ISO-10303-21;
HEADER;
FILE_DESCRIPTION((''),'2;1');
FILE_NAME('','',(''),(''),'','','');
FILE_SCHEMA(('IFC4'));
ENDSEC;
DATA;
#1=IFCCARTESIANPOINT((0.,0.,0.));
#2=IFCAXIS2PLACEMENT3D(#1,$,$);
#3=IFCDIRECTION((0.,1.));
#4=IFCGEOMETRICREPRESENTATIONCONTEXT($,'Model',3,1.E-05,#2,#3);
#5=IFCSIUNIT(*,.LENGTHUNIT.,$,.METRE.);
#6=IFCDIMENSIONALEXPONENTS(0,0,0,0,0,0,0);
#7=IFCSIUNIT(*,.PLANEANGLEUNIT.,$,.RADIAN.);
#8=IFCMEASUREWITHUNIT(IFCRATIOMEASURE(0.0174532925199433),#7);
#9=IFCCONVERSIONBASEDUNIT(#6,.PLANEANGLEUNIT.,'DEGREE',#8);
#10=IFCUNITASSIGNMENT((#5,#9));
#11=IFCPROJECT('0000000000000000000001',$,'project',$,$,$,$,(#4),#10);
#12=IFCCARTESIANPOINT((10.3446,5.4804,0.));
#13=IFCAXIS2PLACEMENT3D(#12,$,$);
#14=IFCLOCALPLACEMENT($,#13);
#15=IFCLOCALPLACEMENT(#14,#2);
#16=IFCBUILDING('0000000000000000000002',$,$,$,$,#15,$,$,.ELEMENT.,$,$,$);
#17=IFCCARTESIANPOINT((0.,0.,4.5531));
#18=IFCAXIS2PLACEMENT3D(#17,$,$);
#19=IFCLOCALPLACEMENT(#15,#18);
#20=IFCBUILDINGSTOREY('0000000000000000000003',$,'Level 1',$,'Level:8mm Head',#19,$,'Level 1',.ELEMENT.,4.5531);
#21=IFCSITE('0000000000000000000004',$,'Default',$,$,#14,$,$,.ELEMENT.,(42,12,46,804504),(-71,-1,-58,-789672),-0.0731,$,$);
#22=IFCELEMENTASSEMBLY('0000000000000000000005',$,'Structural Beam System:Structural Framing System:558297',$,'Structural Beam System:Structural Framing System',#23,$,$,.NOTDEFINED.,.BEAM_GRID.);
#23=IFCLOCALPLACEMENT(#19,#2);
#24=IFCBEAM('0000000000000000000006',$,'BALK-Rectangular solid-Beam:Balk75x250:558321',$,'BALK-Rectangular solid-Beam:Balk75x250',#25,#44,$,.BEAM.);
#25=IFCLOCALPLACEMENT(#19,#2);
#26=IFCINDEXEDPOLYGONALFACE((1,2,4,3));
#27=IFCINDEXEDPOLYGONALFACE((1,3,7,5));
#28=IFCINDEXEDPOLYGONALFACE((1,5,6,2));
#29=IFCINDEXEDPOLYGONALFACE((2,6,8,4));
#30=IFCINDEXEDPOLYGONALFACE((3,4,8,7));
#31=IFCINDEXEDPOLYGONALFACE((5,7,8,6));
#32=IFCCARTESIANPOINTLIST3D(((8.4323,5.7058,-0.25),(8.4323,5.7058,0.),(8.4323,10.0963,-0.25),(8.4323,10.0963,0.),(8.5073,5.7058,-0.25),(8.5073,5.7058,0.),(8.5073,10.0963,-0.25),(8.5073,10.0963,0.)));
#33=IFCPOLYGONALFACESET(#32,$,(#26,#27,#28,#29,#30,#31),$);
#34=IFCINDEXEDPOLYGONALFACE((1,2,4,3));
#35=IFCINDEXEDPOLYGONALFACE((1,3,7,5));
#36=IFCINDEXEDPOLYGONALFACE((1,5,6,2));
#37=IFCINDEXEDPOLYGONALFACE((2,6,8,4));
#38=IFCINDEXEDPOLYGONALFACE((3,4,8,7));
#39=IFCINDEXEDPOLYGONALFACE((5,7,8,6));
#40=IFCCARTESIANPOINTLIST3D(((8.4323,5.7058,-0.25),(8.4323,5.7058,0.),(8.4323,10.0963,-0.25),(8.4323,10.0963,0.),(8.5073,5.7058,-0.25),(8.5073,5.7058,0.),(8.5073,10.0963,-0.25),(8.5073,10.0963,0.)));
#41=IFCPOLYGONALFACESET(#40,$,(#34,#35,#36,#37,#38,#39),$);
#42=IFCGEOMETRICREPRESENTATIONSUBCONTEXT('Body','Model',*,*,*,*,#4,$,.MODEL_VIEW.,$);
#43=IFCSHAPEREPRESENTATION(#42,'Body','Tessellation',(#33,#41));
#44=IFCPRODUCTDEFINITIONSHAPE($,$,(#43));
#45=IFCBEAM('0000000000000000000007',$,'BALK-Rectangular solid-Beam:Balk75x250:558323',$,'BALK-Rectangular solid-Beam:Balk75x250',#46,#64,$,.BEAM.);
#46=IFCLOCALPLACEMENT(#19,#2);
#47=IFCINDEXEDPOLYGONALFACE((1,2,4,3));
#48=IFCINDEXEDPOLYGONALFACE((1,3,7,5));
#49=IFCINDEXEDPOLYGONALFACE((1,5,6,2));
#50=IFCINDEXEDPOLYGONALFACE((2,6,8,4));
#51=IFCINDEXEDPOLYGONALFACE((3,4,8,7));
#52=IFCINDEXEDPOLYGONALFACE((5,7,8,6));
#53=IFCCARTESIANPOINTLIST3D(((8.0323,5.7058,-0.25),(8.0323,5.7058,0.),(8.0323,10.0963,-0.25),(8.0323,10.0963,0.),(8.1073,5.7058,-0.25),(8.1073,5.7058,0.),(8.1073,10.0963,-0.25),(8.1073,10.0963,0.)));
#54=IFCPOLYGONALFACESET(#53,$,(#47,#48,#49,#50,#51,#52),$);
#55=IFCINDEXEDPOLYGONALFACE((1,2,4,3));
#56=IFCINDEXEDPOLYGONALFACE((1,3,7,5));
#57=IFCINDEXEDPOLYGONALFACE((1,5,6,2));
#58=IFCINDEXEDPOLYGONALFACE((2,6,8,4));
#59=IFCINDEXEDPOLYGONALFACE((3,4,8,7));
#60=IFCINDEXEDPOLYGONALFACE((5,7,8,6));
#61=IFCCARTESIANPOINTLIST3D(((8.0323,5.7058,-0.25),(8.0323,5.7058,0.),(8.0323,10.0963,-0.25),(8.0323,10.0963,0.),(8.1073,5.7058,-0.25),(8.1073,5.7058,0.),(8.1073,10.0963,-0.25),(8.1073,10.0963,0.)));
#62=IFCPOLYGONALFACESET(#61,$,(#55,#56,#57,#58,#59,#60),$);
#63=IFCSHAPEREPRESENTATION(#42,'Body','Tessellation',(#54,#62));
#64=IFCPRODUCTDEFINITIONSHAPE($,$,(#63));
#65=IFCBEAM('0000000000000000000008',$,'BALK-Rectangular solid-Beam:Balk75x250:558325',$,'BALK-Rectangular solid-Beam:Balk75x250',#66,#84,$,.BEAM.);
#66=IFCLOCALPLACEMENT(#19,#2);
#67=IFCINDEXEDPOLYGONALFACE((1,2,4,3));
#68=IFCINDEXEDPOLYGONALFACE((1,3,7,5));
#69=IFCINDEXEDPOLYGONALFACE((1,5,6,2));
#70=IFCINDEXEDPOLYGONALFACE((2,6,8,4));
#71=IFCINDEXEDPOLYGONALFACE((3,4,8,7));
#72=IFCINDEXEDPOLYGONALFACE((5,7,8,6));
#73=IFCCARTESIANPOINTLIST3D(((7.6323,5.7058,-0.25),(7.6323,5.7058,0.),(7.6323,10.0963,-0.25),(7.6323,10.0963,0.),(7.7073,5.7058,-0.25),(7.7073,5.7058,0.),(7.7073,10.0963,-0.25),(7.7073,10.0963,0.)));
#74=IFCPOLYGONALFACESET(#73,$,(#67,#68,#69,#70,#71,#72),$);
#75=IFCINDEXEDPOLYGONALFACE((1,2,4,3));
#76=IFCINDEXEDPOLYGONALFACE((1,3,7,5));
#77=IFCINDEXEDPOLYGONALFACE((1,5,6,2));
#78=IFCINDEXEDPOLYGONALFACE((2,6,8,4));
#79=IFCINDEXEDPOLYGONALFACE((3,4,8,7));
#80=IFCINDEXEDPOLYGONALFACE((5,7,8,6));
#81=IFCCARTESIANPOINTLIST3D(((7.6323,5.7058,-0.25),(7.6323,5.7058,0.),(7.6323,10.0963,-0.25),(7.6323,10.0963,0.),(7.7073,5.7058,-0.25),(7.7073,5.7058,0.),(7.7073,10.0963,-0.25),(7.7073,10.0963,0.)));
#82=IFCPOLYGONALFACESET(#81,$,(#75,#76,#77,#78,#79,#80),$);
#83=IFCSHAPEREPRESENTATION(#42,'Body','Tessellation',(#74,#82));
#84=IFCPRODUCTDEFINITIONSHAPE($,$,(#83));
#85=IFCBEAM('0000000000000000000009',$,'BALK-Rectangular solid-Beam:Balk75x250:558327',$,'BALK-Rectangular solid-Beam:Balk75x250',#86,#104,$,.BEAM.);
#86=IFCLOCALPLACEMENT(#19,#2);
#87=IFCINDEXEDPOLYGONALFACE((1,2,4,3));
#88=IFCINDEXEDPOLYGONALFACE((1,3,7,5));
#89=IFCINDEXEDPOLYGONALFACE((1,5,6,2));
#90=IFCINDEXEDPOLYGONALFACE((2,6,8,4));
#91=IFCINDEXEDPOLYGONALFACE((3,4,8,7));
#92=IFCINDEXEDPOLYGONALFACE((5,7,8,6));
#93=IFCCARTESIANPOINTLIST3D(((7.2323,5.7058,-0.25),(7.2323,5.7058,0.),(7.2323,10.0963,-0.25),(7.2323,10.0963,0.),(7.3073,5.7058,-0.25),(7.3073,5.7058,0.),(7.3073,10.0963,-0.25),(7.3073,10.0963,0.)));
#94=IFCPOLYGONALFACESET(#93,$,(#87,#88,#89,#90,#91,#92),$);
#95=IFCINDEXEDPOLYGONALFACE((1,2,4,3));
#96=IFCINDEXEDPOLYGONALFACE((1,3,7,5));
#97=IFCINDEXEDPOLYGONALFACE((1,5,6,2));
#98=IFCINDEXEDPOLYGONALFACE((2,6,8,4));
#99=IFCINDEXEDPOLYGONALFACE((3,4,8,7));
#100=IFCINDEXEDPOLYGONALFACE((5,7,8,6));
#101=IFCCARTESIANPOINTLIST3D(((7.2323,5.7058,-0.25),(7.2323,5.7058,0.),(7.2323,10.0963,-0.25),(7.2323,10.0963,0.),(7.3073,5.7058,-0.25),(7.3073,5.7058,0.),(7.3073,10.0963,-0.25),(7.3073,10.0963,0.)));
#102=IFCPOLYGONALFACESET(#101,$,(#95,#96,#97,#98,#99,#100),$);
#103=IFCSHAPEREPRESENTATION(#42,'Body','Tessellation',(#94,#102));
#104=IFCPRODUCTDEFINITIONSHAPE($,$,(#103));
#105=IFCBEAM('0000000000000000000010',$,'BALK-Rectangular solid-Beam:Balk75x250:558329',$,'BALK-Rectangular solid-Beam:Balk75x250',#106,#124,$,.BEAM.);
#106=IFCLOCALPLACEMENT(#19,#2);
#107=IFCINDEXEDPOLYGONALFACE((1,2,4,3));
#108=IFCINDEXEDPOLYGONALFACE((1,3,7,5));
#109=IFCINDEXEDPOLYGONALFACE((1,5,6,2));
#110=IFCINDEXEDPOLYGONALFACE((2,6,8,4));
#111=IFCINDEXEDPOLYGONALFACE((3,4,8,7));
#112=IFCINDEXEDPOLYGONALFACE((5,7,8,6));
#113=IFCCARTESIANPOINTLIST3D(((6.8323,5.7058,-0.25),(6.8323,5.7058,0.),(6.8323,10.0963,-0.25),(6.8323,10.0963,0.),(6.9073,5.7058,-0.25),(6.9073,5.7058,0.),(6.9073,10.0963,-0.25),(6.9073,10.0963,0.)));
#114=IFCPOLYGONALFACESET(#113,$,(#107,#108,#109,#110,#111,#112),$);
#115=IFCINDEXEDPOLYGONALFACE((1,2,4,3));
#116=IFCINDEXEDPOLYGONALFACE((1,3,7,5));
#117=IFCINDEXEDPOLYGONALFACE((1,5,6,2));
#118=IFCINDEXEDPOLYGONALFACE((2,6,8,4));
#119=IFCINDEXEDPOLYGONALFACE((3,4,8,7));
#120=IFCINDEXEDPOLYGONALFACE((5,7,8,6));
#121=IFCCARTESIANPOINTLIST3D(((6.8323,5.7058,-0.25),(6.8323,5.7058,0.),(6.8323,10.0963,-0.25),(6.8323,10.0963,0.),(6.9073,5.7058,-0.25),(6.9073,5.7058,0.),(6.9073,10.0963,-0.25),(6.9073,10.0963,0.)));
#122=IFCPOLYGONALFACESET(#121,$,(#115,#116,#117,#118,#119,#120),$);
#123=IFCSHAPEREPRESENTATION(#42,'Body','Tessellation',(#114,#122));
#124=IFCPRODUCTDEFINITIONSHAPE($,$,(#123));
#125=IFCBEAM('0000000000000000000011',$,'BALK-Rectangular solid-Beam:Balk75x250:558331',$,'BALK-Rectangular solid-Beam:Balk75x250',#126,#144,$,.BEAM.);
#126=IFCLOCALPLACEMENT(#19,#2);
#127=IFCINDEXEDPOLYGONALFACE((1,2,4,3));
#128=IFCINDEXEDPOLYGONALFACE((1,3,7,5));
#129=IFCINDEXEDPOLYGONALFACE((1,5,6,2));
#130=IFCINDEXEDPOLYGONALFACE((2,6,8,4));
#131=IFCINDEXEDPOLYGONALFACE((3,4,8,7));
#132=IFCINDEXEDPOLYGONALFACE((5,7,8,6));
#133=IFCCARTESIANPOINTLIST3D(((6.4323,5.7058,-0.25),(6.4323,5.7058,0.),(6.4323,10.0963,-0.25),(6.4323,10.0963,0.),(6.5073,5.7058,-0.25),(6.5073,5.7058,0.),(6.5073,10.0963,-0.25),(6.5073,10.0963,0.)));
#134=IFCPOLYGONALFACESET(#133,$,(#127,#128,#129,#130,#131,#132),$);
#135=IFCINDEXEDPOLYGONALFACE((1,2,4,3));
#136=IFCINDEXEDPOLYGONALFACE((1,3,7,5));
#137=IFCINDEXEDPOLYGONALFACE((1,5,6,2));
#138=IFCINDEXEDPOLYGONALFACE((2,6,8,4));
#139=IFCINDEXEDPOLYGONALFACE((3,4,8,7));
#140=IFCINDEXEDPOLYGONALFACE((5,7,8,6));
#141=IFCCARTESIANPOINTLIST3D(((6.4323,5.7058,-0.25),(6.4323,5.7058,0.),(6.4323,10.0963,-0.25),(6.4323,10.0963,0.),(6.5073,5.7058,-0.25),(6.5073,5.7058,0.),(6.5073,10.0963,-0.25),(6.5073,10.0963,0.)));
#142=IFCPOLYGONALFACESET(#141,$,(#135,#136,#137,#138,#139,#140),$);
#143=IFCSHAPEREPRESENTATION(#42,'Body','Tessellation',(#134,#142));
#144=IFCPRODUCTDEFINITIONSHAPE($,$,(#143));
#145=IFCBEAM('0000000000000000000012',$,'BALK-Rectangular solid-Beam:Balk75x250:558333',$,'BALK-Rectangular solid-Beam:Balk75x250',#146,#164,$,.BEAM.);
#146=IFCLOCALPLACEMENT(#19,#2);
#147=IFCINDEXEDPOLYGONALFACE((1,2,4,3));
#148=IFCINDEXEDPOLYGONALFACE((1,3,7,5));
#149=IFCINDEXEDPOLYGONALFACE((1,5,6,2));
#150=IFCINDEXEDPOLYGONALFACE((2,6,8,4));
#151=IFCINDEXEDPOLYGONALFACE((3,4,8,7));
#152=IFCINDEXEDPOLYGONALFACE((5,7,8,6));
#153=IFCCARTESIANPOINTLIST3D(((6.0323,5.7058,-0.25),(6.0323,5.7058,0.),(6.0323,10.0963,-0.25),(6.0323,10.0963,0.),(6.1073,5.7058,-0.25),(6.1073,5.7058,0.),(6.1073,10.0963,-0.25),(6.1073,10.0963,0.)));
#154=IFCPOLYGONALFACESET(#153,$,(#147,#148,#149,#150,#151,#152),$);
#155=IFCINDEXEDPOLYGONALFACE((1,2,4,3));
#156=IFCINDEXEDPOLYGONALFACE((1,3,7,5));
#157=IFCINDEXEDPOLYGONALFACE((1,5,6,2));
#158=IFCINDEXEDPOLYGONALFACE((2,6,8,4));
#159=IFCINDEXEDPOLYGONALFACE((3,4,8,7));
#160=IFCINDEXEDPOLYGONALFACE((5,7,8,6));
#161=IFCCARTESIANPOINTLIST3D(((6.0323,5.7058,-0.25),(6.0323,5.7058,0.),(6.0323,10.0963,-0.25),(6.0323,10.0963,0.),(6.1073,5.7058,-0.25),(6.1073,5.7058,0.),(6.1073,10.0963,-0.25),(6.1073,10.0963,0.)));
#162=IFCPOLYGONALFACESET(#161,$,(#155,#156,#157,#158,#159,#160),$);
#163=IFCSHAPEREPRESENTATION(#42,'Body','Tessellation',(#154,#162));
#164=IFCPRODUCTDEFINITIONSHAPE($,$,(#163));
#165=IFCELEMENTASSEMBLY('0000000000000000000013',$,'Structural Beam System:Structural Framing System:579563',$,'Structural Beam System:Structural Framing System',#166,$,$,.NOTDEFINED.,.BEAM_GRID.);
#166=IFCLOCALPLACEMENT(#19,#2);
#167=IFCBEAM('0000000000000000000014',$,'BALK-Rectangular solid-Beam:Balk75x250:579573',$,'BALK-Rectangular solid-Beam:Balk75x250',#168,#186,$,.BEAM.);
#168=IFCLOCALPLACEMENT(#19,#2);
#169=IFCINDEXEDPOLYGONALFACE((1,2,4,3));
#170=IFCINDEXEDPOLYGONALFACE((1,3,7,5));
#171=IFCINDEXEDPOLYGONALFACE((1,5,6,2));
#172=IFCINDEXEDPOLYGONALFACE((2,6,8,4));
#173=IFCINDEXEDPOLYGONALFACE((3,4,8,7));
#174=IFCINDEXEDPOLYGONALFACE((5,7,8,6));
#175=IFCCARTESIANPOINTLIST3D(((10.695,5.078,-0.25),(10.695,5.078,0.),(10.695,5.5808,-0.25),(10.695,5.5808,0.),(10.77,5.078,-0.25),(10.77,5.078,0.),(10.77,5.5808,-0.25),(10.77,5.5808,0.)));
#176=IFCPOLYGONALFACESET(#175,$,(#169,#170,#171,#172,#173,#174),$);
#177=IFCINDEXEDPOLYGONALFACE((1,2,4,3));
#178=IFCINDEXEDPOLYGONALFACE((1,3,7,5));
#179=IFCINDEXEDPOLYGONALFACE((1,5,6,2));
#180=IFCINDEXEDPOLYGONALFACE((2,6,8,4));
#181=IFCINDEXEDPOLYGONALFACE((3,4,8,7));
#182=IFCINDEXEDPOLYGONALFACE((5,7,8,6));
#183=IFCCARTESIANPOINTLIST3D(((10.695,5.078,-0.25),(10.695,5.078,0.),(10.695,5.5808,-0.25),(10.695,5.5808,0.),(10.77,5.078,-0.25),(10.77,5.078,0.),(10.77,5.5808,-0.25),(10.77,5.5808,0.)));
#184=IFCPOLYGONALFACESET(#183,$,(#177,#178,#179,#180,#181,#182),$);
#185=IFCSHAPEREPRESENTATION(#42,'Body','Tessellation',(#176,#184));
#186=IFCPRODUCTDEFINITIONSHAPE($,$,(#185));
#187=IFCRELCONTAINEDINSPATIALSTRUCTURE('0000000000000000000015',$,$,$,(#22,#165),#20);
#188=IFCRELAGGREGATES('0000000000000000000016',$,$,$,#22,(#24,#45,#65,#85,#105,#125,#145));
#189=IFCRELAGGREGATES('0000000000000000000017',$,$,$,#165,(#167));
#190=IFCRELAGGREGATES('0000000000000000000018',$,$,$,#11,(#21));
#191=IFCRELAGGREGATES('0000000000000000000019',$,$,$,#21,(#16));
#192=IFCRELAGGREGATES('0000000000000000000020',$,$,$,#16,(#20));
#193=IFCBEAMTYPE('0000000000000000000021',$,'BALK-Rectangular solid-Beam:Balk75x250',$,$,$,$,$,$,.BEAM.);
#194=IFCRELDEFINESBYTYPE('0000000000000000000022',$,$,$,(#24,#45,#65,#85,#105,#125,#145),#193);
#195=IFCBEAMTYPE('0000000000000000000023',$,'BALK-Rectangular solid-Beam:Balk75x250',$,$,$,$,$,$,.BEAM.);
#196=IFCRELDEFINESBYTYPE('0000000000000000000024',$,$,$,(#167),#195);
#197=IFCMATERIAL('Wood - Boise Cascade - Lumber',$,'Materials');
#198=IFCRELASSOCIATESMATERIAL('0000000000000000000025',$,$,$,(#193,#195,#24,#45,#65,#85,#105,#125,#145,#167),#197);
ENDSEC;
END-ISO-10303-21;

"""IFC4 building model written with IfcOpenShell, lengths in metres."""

from ifc_helpers import new_model, entity, si_unit, converted_unit, direction, frame, frame_2d, origin, origin_2d_with_axis, place, context, subcontext, project, spatial, rectangle, extrude, source, transform, mapped, material, material_profile, profile_set, profile_usage, type_object, type_shapes, element, aggregate, save


model = new_model("IFC4")

# Units and contexts
model_context = context("Model", 3, precision=1e-05, world=origin(), true_north=direction((0.0, 1.0)))
body_context = subcontext(model_context, "Body", "Model", "MODEL_VIEW")
ifc_project = project(units=[si_unit("LENGTHUNIT", "METRE"), converted_unit("PLANEANGLEUNIT", "DEGREE", entity("IfcRatioMeasure", 0.0174532925199433), si_unit("PLANEANGLEUNIT", "RADIAN"), dimensions=[0, 0, 0, 0, 0, 0, 0])], contexts=[model_context])

# Site, building, storey
site_placement = place(None, frame((10.3446, 5.4804, 0.0)))
site = spatial("IfcSite", under=ifc_project, at=site_placement, Name="Default", CompositionType="ELEMENT", RefLatitude=(42, 12, 46, 804504), RefLongitude=(-71, -1, -58, -789672), RefElevation=-0.0731)
building_placement = place(site_placement, origin())
building = spatial("IfcBuilding", under=site, at=building_placement, CompositionType="ELEMENT")
storey_placement = place(building_placement, frame((0.0, 0.0, 4.5531)))
storey = spatial("IfcBuildingStorey", under=building, at=storey_placement, Name="Level 1", ObjectType="Level:8mm Head", LongName="Level 1", CompositionType="ELEMENT", Elevation=4.5531)

# Element assemblies, beams
assembly_1_placement = place(storey_placement, origin())
assembly_1 = element("IfcElementAssembly", 1, at=assembly_1_placement, inside=storey, Name="Structural Beam System:Structural Framing System:558297", ObjectType="Structural Beam System:Structural Framing System", AssemblyPlace="NOTDEFINED", PredefinedType="BEAM_GRID")
ifc_material_1 = material(Name="Wood - Boise Cascade - Lumber", Category="Materials")
ifc_material_profile = material_profile(ifc_material_1, rectangle(XDim=0.25, YDim=0.075, at=frame_2d((0.0, 0.0), x_axis=(1.0, 0.0))), Name="Balk75x250")
ifc_profile_set = profile_set([ifc_material_profile], Name="Balk75x250")
beam_type_1 = type_object("IfcBeamType", Name="BALK-Rectangular solid-Beam:Balk75x250", PredefinedType="BEAM", material=ifc_profile_set)
shared_shape_1 = source(origin(), body_context, "Body", "SweptSolid", [
    extrude(rectangle(XDim=0.25, YDim=0.075, at=origin_2d_with_axis()), frame((-2.089, 0.0, 0.0), z_axis=(1.0, 0.0, 0.0), x_axis=(0.0, 0.0, -1.0)), (0.0, 0.0, 1.0), 4.3905),
    extrude(rectangle(XDim=0.25, YDim=0.075, at=origin_2d_with_axis()), frame((-2.089, 0.0, 0.0), z_axis=(1.0, 0.0, 0.0), x_axis=(0.0, 0.0, -1.0)), (0.0, 0.0, 1.0), 4.3905),
])
type_shapes(beam_type_1, [shared_shape_1])
ifc_profile_usage_1 = profile_usage(ifc_profile_set, cardinal=8)
beam_1_placement = place(assembly_1_placement, frame((8.4698, 8.0073, -0.125), z_axis=(0.0, 0.0, 1.0), x_axis=(0.0, -1.0, 0.0)))
beam_1 = element("IfcBeam", 2, at=beam_1_placement, type_object=beam_type_1, material=ifc_profile_usage_1, Name="BALK-Rectangular solid-Beam:Balk75x250:558321", ObjectType="BALK-Rectangular solid-Beam:Balk75x250", PredefinedType="BEAM", context=body_context, shape_type="MappedRepresentation", body=[
    mapped(shared_shape_1, transform((0.0, 0.0, 0.0), scale=1.0)),
])
ifc_profile_usage_2 = profile_usage(ifc_profile_set, cardinal=8)
beam_2_placement = place(assembly_1_placement, frame((8.0698, 8.0073, -0.125), z_axis=(0.0, 0.0, 1.0), x_axis=(0.0, -1.0, 0.0)))
beam_2 = element("IfcBeam", 3, at=beam_2_placement, type_object=beam_type_1, material=ifc_profile_usage_2, Name="BALK-Rectangular solid-Beam:Balk75x250:558323", ObjectType="BALK-Rectangular solid-Beam:Balk75x250", PredefinedType="BEAM", context=body_context, shape_type="MappedRepresentation", body=[
    mapped(shared_shape_1, transform((0.0, 0.0, 0.0), scale=1.0)),
])
ifc_profile_usage_3 = profile_usage(ifc_profile_set, cardinal=8)
beam_3_placement = place(assembly_1_placement, frame((7.6698, 8.0073, -0.125), z_axis=(0.0, 0.0, 1.0), x_axis=(0.0, -1.0, 0.0)))
beam_3 = element("IfcBeam", 4, at=beam_3_placement, type_object=beam_type_1, material=ifc_profile_usage_3, Name="BALK-Rectangular solid-Beam:Balk75x250:558325", ObjectType="BALK-Rectangular solid-Beam:Balk75x250", PredefinedType="BEAM", context=body_context, shape_type="MappedRepresentation", body=[
    mapped(shared_shape_1, transform((0.0, 0.0, 0.0), scale=1.0)),
])
ifc_profile_usage_4 = profile_usage(ifc_profile_set, cardinal=8)
beam_4_placement = place(assembly_1_placement, frame((7.2698, 8.0073, -0.125), z_axis=(0.0, 0.0, 1.0), x_axis=(0.0, -1.0, 0.0)))
beam_4 = element("IfcBeam", 5, at=beam_4_placement, type_object=beam_type_1, material=ifc_profile_usage_4, Name="BALK-Rectangular solid-Beam:Balk75x250:558327", ObjectType="BALK-Rectangular solid-Beam:Balk75x250", PredefinedType="BEAM", context=body_context, shape_type="MappedRepresentation", body=[
    mapped(shared_shape_1, transform((0.0, 0.0, 0.0), scale=1.0)),
])
ifc_profile_usage_5 = profile_usage(ifc_profile_set, cardinal=8)
beam_5_placement = place(assembly_1_placement, frame((6.8698, 8.0073, -0.125), z_axis=(0.0, 0.0, 1.0), x_axis=(0.0, -1.0, 0.0)))
beam_5 = element("IfcBeam", 6, at=beam_5_placement, type_object=beam_type_1, material=ifc_profile_usage_5, Name="BALK-Rectangular solid-Beam:Balk75x250:558329", ObjectType="BALK-Rectangular solid-Beam:Balk75x250", PredefinedType="BEAM", context=body_context, shape_type="MappedRepresentation", body=[
    mapped(shared_shape_1, transform((0.0, 0.0, 0.0), scale=1.0)),
])
ifc_profile_usage_6 = profile_usage(ifc_profile_set, cardinal=8)
beam_6_placement = place(assembly_1_placement, frame((6.4698, 8.0073, -0.125), z_axis=(0.0, 0.0, 1.0), x_axis=(0.0, -1.0, 0.0)))
beam_6 = element("IfcBeam", 7, at=beam_6_placement, type_object=beam_type_1, material=ifc_profile_usage_6, Name="BALK-Rectangular solid-Beam:Balk75x250:558331", ObjectType="BALK-Rectangular solid-Beam:Balk75x250", PredefinedType="BEAM", context=body_context, shape_type="MappedRepresentation", body=[
    mapped(shared_shape_1, transform((0.0, 0.0, 0.0), scale=1.0)),
])
ifc_profile_usage_7 = profile_usage(ifc_profile_set, cardinal=8)
beam_7_placement = place(assembly_1_placement, frame((6.0698, 8.0073, -0.125), z_axis=(0.0, 0.0, 1.0), x_axis=(0.0, -1.0, 0.0)))
beam_7 = element("IfcBeam", 8, at=beam_7_placement, type_object=beam_type_1, material=ifc_profile_usage_7, Name="BALK-Rectangular solid-Beam:Balk75x250:558333", ObjectType="BALK-Rectangular solid-Beam:Balk75x250", PredefinedType="BEAM", context=body_context, shape_type="MappedRepresentation", body=[
    mapped(shared_shape_1, transform((0.0, 0.0, 0.0), scale=1.0)),
])
aggregate(assembly_1, [beam_1, beam_2, beam_3, beam_4, beam_5, beam_6, beam_7])
assembly_2_placement = place(storey_placement, origin())
assembly_2 = element("IfcElementAssembly", 9, at=assembly_2_placement, inside=storey, Name="Structural Beam System:Structural Framing System:579563", ObjectType="Structural Beam System:Structural Framing System", AssemblyPlace="NOTDEFINED", PredefinedType="BEAM_GRID")
ifc_profile_usage_8 = profile_usage(ifc_profile_set, cardinal=8)
beam_type_2 = type_object("IfcBeamType", Name="BALK-Rectangular solid-Beam:Balk75x250", PredefinedType="BEAM", material=ifc_profile_set)
shared_shape_2 = source(origin(), body_context, "Body", "SweptSolid", [
    extrude(rectangle(XDim=0.25, YDim=0.075, at=origin_2d_with_axis()), frame((-0.9697, 0.0, 0.0), z_axis=(1.0, 0.0, 0.0), x_axis=(0.0, 0.0, -1.0)), (0.0, 0.0, 1.0), 0.5028),
    extrude(rectangle(XDim=0.25, YDim=0.075, at=origin_2d_with_axis()), frame((-0.9697, 0.0, 0.0), z_axis=(1.0, 0.0, 0.0), x_axis=(0.0, 0.0, -1.0)), (0.0, 0.0, 1.0), 0.5028),
])
type_shapes(beam_type_2, [shared_shape_2])
beam_8_placement = place(assembly_2_placement, frame((10.7325, 4.6111, -0.125), z_axis=(0.0, 0.0, 1.0), x_axis=(0.0, -1.0, 0.0)))
beam_8 = element("IfcBeam", 10, at=beam_8_placement, type_object=beam_type_2, material=ifc_profile_usage_8, Name="BALK-Rectangular solid-Beam:Balk75x250:579573", ObjectType="BALK-Rectangular solid-Beam:Balk75x250", PredefinedType="BEAM", context=body_context, shape_type="MappedRepresentation", body=[
    mapped(shared_shape_2, transform((0.0, 0.0, 0.0), scale=1.0)),
])
aggregate(assembly_2, [beam_8])

save(model, "model.ifc")
